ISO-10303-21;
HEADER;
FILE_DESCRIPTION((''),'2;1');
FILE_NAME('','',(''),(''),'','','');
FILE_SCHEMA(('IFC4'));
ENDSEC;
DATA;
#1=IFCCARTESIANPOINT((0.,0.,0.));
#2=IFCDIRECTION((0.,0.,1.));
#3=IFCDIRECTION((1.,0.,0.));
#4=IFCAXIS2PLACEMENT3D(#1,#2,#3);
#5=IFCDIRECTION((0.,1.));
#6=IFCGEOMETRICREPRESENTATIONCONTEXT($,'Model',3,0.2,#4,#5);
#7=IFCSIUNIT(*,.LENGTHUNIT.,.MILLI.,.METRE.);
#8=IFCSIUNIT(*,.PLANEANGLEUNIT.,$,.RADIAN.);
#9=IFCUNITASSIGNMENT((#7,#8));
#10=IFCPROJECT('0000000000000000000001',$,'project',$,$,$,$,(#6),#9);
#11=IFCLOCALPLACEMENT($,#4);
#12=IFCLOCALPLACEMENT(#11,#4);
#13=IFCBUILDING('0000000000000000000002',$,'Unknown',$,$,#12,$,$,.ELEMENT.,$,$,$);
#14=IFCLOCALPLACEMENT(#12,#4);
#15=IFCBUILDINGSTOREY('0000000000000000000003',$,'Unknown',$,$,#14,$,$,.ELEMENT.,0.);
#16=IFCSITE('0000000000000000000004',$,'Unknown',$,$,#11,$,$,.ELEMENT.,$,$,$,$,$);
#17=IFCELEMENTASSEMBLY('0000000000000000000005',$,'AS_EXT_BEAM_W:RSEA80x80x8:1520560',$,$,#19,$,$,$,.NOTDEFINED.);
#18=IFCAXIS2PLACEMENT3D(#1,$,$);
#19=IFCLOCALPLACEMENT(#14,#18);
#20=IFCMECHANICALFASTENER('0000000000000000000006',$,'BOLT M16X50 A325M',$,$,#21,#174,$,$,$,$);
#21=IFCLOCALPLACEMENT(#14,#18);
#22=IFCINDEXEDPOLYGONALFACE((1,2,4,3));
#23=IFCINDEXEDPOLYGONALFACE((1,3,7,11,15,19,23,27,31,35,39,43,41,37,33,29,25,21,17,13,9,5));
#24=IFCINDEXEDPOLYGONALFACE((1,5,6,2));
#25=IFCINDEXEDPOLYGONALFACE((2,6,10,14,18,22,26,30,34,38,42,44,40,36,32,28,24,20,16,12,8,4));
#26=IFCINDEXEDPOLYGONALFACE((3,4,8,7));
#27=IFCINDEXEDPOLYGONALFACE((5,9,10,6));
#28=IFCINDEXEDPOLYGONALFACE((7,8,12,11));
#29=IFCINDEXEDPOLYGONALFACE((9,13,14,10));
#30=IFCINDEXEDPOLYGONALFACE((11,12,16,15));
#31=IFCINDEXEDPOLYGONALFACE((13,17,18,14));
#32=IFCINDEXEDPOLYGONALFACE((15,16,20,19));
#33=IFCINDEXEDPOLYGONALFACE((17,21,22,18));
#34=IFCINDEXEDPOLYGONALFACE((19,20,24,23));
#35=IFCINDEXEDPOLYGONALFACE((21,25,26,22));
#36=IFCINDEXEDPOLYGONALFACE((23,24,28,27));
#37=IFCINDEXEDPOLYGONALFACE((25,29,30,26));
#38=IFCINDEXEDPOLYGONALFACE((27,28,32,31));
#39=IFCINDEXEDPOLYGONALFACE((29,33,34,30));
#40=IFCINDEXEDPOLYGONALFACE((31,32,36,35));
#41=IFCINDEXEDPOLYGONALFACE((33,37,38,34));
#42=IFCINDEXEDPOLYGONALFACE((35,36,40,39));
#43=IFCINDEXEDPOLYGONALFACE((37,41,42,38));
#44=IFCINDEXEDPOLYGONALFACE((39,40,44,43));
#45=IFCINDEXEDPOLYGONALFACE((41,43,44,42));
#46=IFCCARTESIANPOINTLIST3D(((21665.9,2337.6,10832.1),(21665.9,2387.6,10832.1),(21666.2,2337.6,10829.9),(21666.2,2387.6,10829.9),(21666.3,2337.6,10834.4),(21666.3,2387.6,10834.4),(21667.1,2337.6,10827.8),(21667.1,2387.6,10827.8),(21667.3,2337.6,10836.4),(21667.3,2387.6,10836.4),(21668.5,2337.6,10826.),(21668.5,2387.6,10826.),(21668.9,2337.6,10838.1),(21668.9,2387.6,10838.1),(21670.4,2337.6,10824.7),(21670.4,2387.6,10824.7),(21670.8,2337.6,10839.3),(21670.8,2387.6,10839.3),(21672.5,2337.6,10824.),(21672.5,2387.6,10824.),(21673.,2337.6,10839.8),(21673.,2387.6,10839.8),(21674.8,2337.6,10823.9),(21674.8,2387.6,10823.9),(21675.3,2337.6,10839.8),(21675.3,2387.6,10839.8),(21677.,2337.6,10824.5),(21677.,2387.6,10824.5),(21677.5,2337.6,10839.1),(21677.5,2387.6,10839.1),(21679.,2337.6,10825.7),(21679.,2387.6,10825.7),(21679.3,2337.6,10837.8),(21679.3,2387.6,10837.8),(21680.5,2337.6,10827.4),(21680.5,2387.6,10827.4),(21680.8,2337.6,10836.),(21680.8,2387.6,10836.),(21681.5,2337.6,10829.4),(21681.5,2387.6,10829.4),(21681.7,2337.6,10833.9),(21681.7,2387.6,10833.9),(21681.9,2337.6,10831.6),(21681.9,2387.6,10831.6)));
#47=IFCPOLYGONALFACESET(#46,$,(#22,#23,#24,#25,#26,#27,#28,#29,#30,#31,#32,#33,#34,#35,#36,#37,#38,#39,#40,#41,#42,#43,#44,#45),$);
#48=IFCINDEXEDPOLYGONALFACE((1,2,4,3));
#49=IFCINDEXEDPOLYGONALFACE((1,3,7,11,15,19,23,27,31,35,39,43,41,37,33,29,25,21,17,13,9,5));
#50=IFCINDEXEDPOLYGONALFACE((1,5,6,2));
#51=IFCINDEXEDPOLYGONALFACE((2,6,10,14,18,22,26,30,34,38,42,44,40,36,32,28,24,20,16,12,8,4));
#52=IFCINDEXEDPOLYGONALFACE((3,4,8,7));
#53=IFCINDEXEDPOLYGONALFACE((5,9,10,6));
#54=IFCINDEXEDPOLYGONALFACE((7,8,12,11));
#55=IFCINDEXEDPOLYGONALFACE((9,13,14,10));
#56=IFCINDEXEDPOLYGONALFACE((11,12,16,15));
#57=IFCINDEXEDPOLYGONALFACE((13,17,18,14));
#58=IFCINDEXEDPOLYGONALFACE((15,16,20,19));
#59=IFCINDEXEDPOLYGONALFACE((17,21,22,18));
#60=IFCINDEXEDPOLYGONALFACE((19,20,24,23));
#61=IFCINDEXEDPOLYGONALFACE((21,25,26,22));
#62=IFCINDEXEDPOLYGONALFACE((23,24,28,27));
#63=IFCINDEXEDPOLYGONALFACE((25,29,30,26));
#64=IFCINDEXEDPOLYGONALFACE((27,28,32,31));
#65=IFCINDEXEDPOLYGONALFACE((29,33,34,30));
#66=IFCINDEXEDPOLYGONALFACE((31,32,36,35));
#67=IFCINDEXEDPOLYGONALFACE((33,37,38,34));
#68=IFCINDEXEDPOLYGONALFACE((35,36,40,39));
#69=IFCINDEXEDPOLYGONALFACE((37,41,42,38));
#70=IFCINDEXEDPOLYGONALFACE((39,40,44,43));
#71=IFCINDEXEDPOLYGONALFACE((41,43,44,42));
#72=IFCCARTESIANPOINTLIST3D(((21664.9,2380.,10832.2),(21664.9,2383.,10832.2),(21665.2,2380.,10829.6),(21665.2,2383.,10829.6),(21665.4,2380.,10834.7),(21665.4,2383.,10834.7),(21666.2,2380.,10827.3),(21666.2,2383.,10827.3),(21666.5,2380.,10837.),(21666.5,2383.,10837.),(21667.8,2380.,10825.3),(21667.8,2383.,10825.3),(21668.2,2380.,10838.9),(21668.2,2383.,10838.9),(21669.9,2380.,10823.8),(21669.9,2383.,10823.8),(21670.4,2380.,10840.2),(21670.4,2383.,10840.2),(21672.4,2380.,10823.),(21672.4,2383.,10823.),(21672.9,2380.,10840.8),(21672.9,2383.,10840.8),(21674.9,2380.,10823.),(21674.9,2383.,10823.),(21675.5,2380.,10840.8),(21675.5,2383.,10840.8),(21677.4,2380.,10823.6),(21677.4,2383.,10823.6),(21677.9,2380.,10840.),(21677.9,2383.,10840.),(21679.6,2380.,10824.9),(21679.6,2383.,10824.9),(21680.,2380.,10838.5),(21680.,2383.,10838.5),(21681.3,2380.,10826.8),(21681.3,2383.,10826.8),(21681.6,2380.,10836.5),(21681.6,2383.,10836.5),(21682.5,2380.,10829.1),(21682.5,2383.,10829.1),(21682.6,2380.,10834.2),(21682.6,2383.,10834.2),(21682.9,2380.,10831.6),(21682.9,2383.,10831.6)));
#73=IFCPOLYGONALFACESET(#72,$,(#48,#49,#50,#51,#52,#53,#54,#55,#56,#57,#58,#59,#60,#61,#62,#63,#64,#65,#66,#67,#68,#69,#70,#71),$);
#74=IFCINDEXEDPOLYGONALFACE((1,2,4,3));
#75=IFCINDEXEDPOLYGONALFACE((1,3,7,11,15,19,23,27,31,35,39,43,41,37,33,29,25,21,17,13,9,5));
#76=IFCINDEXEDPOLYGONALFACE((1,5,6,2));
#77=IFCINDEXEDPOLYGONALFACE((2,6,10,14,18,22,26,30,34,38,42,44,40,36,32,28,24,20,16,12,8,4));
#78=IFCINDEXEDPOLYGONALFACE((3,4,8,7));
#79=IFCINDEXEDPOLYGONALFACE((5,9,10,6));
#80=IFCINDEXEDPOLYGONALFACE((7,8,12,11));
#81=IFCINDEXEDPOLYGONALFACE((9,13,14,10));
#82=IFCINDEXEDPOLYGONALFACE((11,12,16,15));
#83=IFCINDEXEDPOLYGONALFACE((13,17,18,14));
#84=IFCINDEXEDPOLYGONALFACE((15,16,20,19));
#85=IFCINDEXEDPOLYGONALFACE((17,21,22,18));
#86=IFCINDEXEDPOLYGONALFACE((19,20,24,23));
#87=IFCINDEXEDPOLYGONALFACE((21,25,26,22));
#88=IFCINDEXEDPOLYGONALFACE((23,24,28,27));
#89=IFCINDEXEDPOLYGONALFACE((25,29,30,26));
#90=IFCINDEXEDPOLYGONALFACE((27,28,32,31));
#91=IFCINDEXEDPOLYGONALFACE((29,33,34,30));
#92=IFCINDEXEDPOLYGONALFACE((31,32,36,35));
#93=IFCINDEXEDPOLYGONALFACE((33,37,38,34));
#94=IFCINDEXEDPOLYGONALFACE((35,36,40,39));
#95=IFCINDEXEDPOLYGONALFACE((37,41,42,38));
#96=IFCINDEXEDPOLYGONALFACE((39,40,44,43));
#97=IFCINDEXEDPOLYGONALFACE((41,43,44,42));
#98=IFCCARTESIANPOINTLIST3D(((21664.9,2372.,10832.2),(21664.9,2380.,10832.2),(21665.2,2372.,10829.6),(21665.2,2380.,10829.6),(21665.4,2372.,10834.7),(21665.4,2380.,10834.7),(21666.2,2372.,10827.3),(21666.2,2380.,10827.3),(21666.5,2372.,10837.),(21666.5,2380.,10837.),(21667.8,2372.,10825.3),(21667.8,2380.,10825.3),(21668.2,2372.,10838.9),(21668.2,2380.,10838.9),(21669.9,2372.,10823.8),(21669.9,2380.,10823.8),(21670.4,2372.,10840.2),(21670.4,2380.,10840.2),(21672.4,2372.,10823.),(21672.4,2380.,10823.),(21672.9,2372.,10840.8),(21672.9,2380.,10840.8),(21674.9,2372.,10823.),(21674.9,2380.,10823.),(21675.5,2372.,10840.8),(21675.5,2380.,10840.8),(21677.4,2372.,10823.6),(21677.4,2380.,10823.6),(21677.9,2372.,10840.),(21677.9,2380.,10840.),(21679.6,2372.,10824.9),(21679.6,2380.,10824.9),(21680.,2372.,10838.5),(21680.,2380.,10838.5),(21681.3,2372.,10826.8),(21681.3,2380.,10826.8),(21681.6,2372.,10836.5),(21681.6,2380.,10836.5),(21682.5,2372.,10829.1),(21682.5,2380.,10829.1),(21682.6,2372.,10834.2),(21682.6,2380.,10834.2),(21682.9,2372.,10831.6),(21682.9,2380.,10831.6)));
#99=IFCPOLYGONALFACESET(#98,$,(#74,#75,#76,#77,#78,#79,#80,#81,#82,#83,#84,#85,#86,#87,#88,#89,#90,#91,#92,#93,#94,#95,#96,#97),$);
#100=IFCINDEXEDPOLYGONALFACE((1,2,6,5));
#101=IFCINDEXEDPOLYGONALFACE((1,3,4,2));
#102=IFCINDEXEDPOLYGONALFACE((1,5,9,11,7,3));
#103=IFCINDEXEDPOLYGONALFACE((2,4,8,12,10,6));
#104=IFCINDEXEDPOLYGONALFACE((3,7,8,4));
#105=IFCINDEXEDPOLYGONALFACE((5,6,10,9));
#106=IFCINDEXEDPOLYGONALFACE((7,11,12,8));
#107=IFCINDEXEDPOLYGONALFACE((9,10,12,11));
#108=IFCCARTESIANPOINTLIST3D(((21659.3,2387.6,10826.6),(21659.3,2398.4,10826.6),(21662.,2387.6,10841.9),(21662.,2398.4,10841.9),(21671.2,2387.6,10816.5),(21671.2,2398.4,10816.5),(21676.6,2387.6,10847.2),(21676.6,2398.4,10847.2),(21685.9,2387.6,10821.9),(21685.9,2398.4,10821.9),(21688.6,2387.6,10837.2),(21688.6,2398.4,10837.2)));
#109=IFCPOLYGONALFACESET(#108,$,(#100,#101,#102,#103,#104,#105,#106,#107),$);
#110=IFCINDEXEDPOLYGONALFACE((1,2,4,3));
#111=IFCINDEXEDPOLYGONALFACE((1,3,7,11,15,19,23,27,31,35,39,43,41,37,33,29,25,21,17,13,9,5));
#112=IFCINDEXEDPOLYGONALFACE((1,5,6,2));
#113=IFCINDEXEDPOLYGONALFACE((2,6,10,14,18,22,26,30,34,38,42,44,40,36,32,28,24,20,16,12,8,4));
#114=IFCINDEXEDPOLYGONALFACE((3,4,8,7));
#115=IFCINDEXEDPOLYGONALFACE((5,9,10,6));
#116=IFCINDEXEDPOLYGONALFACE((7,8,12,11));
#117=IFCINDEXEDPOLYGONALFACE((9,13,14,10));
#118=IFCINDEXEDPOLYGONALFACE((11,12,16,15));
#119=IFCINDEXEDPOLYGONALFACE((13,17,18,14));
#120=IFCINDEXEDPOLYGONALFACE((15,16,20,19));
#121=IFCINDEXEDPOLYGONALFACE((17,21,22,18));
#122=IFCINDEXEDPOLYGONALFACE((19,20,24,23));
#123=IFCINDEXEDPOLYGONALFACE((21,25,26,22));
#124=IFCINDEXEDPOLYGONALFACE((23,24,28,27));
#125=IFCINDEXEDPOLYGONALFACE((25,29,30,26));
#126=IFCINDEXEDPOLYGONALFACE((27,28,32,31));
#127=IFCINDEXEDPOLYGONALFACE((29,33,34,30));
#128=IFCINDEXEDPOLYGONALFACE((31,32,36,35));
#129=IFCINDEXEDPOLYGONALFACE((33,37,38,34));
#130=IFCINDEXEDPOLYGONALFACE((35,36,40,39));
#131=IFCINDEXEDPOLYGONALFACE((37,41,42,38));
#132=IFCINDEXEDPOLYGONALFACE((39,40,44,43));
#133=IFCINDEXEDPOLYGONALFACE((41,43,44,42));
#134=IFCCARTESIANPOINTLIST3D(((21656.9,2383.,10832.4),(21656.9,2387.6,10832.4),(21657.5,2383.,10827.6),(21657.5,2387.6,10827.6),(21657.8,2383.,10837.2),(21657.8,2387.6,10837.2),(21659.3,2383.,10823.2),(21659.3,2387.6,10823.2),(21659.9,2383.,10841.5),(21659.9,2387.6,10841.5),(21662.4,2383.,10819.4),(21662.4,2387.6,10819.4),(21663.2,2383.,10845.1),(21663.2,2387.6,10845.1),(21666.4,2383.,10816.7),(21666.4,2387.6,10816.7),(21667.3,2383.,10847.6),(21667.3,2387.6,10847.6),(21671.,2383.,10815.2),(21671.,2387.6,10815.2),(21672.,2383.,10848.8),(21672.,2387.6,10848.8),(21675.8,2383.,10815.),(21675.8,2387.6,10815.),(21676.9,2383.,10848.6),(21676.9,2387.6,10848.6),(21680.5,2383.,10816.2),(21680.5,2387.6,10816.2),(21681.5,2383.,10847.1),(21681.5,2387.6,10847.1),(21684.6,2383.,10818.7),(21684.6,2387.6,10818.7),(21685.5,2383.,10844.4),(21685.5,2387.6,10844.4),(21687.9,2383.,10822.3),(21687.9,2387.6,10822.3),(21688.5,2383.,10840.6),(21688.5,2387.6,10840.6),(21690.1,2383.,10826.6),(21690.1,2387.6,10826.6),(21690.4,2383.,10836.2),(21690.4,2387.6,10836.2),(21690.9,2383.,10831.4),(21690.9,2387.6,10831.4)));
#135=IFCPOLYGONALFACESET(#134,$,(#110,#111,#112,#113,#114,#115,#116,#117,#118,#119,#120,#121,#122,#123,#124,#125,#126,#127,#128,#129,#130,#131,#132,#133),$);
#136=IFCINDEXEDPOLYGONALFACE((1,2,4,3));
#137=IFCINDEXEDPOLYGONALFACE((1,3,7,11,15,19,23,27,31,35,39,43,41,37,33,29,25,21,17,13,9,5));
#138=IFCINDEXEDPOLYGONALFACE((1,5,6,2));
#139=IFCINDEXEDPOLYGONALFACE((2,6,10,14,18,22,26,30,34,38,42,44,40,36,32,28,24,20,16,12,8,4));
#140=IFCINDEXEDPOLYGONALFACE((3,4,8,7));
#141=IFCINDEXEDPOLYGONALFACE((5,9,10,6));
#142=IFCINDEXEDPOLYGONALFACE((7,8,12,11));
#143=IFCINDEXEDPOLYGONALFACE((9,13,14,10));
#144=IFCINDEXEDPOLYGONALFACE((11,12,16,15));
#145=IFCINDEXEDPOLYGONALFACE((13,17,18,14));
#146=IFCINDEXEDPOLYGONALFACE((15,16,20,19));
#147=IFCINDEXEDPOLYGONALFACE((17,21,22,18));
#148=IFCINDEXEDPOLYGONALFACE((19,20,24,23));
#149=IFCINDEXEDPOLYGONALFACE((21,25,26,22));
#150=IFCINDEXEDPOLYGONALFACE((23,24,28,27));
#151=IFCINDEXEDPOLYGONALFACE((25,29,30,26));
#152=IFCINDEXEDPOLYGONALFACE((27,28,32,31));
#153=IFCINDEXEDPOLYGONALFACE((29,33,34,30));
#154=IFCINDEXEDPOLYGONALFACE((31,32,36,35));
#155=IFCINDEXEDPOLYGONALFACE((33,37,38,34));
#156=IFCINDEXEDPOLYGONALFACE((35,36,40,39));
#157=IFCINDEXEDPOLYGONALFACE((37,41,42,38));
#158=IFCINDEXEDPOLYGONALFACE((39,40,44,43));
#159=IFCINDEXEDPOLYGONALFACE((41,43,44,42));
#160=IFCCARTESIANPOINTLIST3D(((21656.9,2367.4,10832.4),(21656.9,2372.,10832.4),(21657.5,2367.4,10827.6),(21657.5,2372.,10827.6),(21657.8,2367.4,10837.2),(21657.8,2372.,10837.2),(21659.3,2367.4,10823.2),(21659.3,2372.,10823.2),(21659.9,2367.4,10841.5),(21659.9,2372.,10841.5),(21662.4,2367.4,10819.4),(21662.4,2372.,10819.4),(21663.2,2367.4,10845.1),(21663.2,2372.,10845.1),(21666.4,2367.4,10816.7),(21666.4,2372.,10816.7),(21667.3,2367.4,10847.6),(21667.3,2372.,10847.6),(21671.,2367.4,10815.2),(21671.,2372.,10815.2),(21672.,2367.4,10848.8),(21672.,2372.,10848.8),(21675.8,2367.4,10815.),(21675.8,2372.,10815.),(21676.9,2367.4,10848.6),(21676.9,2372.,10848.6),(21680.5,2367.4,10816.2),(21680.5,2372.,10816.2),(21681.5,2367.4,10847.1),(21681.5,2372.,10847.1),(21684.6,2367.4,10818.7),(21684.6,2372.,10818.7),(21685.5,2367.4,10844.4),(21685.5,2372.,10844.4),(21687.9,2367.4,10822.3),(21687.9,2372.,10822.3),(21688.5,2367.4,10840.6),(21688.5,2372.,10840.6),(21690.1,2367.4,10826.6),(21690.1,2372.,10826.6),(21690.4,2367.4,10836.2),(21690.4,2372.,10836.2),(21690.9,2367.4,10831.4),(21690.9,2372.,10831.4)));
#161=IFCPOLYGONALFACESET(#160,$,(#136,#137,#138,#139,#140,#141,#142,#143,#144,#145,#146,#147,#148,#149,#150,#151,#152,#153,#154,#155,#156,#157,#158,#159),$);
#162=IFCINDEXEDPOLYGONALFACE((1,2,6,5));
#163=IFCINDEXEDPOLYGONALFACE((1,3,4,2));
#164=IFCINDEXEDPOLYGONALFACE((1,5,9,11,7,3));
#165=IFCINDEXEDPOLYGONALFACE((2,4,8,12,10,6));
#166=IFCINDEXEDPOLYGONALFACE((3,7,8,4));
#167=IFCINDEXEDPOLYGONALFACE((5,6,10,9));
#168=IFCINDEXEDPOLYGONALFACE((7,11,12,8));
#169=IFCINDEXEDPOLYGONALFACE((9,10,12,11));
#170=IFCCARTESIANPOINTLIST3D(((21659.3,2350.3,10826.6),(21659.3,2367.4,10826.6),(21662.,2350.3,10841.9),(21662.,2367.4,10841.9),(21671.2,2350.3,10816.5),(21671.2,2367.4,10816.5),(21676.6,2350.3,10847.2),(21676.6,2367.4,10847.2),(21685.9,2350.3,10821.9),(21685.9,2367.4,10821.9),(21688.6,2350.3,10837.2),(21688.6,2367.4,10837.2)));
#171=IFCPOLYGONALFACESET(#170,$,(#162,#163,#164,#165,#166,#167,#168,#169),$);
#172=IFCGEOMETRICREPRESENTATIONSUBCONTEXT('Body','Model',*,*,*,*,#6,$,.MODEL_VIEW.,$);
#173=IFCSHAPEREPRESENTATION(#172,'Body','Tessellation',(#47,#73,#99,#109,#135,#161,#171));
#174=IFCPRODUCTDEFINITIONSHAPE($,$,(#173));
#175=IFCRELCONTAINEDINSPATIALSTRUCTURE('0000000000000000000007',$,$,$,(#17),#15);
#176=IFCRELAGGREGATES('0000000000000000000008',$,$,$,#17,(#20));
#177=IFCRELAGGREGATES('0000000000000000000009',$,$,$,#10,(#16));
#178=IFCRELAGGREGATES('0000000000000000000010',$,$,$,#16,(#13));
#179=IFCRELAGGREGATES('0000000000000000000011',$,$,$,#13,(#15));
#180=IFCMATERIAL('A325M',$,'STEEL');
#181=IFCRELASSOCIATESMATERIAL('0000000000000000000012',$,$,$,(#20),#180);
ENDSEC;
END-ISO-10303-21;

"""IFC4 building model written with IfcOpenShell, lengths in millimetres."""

from ifc_helpers import new_model, si_unit, direction, frame, origin_with_axes, place, context, subcontext, project, spatial, line, arc, indexed_curve, outline, extrude, source, transform, mapped, material, element, aggregate, save


model = new_model("IFC4")

# Units and contexts
model_context = context("Model", 3, precision=0.2, world=origin_with_axes(), true_north=direction((0.0, 1.0)))
body_context = subcontext(model_context, "Body", "Model", "MODEL_VIEW")
ifc_project = project(units=[si_unit("LENGTHUNIT", "METRE", prefix="MILLI"), si_unit("PLANEANGLEUNIT", "RADIAN")], contexts=[model_context])

# Site, building, storey
site_placement = place(None, origin_with_axes())
site = spatial("IfcSite", under=ifc_project, at=site_placement, Name="Unknown", CompositionType="ELEMENT")
building_placement = place(site_placement, origin_with_axes())
building = spatial("IfcBuilding", under=site, at=building_placement, Name="Unknown", CompositionType="ELEMENT")
storey_placement = place(building_placement, origin_with_axes())
storey = spatial("IfcBuildingStorey", under=building, at=storey_placement, Name="Unknown", CompositionType="ELEMENT", Elevation=0.0)

# Shared definitions
ifc_material_1 = material(Name="A325M", Category="STEEL")
shared_shape = source(origin_with_axes(), body_context, "Body", "SweptSolid", [
    extrude(outline(indexed_curve([(8.0, 0.0), (0.0, 8.0), (-8.0, 0.0), (0.0, -8.0)], segments=[arc(1, 2, 3), arc(3, 4, 1)])), frame((0.0, 0.0, 15.6), z_axis=(0.0, 0.0, -1.0), x_axis=(0.0, 1.0, 0.0)), (0.0, 0.0, 1.0), 50.0),
    extrude(outline(indexed_curve([(9.0, 0.0), (0.0, 9.0), (-9.0, 0.0), (0.0, -9.0)], segments=[arc(1, 2, 3), arc(3, 4, 1)])), frame((0.0, 0.0, 11.0), z_axis=(0.0, 0.0, -1.0), x_axis=(0.0, 1.0, 0.0)), (0.0, 0.0, 1.0), 3.0),
    extrude(outline(indexed_curve([(9.0, 0.0), (0.0, 9.0), (-9.0, 0.0), (0.0, -9.0)], segments=[arc(1, 2, 3), arc(3, 4, 1)])), frame((0.0, 0.0, 8.0), z_axis=(0.0, 0.0, -1.0), x_axis=(0.0, 1.0, 0.0)), (0.0, 0.0, 1.0), 8.0),
    extrude(outline(indexed_curve([(15.6, 0.0), (7.8, 13.5), (-7.8, 13.5), (-15.6, 0.0), (-7.8, -13.5), (7.8, -13.5)], segments=[line(1, 2, 3, 4, 5, 6, 1)])), frame((0.0, 0.0, 26.4), z_axis=(0.0, 0.0, -1.0), x_axis=(0.0, 1.0, 0.0)), (0.0, 0.0, 1.0), 10.8),
    extrude(outline(indexed_curve([(17.0, 0.0), (0.0, 17.0), (-17.0, 0.0), (0.0, -17.0)], segments=[arc(1, 2, 3), arc(3, 4, 1)])), frame((0.0, 0.0, 15.6), z_axis=(0.0, 0.0, -1.0), x_axis=(0.0, 1.0, 0.0)), (0.0, 0.0, 1.0), 4.6),
    extrude(outline(indexed_curve([(17.0, 0.0), (0.0, 17.0), (-17.0, 0.0), (0.0, -17.0)], segments=[arc(1, 2, 3), arc(3, 4, 1)])), frame((0.0, 0.0, 0.0), z_axis=(0.0, 0.0, -1.0), x_axis=(0.0, 1.0, 0.0)), (0.0, 0.0, 1.0), 4.6),
    extrude(outline(indexed_curve([(15.6, 0.0), (7.8, 13.5), (-7.8, 13.5), (-15.6, 0.0), (-7.8, -13.5), (7.8, -13.5)], segments=[line(1, 2, 3, 4, 5, 6, 1)])), frame((0.0, 0.0, -4.6), z_axis=(0.0, 0.0, -1.0), x_axis=(0.0, 1.0, 0.0)), (0.0, 0.0, 1.0), 17.1),
])

# Element assembly, mechanical fastener
assembly_1_placement = place(storey_placement, frame((21611.5, 2340.0, 10837.8), z_axis=(0.0, -1.0, 0.0), x_axis=(0.984808, 0.0, -0.173648)))
assembly_1 = element("IfcElementAssembly", 1, at=assembly_1_placement, inside=storey, Name="AS_EXT_BEAM_W:RSEA80x80x8:1520560", PredefinedType="NOTDEFINED")
mechanical_fastener_1_placement = place(assembly_1_placement, frame((62.5, 5.0, -32.0), z_axis=(0.0, 0.0, -1.0), x_axis=(1.0, 0.0, 0.0)))
mechanical_fastener_1 = element("IfcMechanicalFastener", 2, at=mechanical_fastener_1_placement, material=ifc_material_1, Name="BOLT M16X50 A325M", context=body_context, shape_type="MappedRepresentation", body=[
    mapped(shared_shape, transform((0.0, 0.0, 0.0))),
])
aggregate(assembly_1, [mechanical_fastener_1])

save(model, "model.ifc")
